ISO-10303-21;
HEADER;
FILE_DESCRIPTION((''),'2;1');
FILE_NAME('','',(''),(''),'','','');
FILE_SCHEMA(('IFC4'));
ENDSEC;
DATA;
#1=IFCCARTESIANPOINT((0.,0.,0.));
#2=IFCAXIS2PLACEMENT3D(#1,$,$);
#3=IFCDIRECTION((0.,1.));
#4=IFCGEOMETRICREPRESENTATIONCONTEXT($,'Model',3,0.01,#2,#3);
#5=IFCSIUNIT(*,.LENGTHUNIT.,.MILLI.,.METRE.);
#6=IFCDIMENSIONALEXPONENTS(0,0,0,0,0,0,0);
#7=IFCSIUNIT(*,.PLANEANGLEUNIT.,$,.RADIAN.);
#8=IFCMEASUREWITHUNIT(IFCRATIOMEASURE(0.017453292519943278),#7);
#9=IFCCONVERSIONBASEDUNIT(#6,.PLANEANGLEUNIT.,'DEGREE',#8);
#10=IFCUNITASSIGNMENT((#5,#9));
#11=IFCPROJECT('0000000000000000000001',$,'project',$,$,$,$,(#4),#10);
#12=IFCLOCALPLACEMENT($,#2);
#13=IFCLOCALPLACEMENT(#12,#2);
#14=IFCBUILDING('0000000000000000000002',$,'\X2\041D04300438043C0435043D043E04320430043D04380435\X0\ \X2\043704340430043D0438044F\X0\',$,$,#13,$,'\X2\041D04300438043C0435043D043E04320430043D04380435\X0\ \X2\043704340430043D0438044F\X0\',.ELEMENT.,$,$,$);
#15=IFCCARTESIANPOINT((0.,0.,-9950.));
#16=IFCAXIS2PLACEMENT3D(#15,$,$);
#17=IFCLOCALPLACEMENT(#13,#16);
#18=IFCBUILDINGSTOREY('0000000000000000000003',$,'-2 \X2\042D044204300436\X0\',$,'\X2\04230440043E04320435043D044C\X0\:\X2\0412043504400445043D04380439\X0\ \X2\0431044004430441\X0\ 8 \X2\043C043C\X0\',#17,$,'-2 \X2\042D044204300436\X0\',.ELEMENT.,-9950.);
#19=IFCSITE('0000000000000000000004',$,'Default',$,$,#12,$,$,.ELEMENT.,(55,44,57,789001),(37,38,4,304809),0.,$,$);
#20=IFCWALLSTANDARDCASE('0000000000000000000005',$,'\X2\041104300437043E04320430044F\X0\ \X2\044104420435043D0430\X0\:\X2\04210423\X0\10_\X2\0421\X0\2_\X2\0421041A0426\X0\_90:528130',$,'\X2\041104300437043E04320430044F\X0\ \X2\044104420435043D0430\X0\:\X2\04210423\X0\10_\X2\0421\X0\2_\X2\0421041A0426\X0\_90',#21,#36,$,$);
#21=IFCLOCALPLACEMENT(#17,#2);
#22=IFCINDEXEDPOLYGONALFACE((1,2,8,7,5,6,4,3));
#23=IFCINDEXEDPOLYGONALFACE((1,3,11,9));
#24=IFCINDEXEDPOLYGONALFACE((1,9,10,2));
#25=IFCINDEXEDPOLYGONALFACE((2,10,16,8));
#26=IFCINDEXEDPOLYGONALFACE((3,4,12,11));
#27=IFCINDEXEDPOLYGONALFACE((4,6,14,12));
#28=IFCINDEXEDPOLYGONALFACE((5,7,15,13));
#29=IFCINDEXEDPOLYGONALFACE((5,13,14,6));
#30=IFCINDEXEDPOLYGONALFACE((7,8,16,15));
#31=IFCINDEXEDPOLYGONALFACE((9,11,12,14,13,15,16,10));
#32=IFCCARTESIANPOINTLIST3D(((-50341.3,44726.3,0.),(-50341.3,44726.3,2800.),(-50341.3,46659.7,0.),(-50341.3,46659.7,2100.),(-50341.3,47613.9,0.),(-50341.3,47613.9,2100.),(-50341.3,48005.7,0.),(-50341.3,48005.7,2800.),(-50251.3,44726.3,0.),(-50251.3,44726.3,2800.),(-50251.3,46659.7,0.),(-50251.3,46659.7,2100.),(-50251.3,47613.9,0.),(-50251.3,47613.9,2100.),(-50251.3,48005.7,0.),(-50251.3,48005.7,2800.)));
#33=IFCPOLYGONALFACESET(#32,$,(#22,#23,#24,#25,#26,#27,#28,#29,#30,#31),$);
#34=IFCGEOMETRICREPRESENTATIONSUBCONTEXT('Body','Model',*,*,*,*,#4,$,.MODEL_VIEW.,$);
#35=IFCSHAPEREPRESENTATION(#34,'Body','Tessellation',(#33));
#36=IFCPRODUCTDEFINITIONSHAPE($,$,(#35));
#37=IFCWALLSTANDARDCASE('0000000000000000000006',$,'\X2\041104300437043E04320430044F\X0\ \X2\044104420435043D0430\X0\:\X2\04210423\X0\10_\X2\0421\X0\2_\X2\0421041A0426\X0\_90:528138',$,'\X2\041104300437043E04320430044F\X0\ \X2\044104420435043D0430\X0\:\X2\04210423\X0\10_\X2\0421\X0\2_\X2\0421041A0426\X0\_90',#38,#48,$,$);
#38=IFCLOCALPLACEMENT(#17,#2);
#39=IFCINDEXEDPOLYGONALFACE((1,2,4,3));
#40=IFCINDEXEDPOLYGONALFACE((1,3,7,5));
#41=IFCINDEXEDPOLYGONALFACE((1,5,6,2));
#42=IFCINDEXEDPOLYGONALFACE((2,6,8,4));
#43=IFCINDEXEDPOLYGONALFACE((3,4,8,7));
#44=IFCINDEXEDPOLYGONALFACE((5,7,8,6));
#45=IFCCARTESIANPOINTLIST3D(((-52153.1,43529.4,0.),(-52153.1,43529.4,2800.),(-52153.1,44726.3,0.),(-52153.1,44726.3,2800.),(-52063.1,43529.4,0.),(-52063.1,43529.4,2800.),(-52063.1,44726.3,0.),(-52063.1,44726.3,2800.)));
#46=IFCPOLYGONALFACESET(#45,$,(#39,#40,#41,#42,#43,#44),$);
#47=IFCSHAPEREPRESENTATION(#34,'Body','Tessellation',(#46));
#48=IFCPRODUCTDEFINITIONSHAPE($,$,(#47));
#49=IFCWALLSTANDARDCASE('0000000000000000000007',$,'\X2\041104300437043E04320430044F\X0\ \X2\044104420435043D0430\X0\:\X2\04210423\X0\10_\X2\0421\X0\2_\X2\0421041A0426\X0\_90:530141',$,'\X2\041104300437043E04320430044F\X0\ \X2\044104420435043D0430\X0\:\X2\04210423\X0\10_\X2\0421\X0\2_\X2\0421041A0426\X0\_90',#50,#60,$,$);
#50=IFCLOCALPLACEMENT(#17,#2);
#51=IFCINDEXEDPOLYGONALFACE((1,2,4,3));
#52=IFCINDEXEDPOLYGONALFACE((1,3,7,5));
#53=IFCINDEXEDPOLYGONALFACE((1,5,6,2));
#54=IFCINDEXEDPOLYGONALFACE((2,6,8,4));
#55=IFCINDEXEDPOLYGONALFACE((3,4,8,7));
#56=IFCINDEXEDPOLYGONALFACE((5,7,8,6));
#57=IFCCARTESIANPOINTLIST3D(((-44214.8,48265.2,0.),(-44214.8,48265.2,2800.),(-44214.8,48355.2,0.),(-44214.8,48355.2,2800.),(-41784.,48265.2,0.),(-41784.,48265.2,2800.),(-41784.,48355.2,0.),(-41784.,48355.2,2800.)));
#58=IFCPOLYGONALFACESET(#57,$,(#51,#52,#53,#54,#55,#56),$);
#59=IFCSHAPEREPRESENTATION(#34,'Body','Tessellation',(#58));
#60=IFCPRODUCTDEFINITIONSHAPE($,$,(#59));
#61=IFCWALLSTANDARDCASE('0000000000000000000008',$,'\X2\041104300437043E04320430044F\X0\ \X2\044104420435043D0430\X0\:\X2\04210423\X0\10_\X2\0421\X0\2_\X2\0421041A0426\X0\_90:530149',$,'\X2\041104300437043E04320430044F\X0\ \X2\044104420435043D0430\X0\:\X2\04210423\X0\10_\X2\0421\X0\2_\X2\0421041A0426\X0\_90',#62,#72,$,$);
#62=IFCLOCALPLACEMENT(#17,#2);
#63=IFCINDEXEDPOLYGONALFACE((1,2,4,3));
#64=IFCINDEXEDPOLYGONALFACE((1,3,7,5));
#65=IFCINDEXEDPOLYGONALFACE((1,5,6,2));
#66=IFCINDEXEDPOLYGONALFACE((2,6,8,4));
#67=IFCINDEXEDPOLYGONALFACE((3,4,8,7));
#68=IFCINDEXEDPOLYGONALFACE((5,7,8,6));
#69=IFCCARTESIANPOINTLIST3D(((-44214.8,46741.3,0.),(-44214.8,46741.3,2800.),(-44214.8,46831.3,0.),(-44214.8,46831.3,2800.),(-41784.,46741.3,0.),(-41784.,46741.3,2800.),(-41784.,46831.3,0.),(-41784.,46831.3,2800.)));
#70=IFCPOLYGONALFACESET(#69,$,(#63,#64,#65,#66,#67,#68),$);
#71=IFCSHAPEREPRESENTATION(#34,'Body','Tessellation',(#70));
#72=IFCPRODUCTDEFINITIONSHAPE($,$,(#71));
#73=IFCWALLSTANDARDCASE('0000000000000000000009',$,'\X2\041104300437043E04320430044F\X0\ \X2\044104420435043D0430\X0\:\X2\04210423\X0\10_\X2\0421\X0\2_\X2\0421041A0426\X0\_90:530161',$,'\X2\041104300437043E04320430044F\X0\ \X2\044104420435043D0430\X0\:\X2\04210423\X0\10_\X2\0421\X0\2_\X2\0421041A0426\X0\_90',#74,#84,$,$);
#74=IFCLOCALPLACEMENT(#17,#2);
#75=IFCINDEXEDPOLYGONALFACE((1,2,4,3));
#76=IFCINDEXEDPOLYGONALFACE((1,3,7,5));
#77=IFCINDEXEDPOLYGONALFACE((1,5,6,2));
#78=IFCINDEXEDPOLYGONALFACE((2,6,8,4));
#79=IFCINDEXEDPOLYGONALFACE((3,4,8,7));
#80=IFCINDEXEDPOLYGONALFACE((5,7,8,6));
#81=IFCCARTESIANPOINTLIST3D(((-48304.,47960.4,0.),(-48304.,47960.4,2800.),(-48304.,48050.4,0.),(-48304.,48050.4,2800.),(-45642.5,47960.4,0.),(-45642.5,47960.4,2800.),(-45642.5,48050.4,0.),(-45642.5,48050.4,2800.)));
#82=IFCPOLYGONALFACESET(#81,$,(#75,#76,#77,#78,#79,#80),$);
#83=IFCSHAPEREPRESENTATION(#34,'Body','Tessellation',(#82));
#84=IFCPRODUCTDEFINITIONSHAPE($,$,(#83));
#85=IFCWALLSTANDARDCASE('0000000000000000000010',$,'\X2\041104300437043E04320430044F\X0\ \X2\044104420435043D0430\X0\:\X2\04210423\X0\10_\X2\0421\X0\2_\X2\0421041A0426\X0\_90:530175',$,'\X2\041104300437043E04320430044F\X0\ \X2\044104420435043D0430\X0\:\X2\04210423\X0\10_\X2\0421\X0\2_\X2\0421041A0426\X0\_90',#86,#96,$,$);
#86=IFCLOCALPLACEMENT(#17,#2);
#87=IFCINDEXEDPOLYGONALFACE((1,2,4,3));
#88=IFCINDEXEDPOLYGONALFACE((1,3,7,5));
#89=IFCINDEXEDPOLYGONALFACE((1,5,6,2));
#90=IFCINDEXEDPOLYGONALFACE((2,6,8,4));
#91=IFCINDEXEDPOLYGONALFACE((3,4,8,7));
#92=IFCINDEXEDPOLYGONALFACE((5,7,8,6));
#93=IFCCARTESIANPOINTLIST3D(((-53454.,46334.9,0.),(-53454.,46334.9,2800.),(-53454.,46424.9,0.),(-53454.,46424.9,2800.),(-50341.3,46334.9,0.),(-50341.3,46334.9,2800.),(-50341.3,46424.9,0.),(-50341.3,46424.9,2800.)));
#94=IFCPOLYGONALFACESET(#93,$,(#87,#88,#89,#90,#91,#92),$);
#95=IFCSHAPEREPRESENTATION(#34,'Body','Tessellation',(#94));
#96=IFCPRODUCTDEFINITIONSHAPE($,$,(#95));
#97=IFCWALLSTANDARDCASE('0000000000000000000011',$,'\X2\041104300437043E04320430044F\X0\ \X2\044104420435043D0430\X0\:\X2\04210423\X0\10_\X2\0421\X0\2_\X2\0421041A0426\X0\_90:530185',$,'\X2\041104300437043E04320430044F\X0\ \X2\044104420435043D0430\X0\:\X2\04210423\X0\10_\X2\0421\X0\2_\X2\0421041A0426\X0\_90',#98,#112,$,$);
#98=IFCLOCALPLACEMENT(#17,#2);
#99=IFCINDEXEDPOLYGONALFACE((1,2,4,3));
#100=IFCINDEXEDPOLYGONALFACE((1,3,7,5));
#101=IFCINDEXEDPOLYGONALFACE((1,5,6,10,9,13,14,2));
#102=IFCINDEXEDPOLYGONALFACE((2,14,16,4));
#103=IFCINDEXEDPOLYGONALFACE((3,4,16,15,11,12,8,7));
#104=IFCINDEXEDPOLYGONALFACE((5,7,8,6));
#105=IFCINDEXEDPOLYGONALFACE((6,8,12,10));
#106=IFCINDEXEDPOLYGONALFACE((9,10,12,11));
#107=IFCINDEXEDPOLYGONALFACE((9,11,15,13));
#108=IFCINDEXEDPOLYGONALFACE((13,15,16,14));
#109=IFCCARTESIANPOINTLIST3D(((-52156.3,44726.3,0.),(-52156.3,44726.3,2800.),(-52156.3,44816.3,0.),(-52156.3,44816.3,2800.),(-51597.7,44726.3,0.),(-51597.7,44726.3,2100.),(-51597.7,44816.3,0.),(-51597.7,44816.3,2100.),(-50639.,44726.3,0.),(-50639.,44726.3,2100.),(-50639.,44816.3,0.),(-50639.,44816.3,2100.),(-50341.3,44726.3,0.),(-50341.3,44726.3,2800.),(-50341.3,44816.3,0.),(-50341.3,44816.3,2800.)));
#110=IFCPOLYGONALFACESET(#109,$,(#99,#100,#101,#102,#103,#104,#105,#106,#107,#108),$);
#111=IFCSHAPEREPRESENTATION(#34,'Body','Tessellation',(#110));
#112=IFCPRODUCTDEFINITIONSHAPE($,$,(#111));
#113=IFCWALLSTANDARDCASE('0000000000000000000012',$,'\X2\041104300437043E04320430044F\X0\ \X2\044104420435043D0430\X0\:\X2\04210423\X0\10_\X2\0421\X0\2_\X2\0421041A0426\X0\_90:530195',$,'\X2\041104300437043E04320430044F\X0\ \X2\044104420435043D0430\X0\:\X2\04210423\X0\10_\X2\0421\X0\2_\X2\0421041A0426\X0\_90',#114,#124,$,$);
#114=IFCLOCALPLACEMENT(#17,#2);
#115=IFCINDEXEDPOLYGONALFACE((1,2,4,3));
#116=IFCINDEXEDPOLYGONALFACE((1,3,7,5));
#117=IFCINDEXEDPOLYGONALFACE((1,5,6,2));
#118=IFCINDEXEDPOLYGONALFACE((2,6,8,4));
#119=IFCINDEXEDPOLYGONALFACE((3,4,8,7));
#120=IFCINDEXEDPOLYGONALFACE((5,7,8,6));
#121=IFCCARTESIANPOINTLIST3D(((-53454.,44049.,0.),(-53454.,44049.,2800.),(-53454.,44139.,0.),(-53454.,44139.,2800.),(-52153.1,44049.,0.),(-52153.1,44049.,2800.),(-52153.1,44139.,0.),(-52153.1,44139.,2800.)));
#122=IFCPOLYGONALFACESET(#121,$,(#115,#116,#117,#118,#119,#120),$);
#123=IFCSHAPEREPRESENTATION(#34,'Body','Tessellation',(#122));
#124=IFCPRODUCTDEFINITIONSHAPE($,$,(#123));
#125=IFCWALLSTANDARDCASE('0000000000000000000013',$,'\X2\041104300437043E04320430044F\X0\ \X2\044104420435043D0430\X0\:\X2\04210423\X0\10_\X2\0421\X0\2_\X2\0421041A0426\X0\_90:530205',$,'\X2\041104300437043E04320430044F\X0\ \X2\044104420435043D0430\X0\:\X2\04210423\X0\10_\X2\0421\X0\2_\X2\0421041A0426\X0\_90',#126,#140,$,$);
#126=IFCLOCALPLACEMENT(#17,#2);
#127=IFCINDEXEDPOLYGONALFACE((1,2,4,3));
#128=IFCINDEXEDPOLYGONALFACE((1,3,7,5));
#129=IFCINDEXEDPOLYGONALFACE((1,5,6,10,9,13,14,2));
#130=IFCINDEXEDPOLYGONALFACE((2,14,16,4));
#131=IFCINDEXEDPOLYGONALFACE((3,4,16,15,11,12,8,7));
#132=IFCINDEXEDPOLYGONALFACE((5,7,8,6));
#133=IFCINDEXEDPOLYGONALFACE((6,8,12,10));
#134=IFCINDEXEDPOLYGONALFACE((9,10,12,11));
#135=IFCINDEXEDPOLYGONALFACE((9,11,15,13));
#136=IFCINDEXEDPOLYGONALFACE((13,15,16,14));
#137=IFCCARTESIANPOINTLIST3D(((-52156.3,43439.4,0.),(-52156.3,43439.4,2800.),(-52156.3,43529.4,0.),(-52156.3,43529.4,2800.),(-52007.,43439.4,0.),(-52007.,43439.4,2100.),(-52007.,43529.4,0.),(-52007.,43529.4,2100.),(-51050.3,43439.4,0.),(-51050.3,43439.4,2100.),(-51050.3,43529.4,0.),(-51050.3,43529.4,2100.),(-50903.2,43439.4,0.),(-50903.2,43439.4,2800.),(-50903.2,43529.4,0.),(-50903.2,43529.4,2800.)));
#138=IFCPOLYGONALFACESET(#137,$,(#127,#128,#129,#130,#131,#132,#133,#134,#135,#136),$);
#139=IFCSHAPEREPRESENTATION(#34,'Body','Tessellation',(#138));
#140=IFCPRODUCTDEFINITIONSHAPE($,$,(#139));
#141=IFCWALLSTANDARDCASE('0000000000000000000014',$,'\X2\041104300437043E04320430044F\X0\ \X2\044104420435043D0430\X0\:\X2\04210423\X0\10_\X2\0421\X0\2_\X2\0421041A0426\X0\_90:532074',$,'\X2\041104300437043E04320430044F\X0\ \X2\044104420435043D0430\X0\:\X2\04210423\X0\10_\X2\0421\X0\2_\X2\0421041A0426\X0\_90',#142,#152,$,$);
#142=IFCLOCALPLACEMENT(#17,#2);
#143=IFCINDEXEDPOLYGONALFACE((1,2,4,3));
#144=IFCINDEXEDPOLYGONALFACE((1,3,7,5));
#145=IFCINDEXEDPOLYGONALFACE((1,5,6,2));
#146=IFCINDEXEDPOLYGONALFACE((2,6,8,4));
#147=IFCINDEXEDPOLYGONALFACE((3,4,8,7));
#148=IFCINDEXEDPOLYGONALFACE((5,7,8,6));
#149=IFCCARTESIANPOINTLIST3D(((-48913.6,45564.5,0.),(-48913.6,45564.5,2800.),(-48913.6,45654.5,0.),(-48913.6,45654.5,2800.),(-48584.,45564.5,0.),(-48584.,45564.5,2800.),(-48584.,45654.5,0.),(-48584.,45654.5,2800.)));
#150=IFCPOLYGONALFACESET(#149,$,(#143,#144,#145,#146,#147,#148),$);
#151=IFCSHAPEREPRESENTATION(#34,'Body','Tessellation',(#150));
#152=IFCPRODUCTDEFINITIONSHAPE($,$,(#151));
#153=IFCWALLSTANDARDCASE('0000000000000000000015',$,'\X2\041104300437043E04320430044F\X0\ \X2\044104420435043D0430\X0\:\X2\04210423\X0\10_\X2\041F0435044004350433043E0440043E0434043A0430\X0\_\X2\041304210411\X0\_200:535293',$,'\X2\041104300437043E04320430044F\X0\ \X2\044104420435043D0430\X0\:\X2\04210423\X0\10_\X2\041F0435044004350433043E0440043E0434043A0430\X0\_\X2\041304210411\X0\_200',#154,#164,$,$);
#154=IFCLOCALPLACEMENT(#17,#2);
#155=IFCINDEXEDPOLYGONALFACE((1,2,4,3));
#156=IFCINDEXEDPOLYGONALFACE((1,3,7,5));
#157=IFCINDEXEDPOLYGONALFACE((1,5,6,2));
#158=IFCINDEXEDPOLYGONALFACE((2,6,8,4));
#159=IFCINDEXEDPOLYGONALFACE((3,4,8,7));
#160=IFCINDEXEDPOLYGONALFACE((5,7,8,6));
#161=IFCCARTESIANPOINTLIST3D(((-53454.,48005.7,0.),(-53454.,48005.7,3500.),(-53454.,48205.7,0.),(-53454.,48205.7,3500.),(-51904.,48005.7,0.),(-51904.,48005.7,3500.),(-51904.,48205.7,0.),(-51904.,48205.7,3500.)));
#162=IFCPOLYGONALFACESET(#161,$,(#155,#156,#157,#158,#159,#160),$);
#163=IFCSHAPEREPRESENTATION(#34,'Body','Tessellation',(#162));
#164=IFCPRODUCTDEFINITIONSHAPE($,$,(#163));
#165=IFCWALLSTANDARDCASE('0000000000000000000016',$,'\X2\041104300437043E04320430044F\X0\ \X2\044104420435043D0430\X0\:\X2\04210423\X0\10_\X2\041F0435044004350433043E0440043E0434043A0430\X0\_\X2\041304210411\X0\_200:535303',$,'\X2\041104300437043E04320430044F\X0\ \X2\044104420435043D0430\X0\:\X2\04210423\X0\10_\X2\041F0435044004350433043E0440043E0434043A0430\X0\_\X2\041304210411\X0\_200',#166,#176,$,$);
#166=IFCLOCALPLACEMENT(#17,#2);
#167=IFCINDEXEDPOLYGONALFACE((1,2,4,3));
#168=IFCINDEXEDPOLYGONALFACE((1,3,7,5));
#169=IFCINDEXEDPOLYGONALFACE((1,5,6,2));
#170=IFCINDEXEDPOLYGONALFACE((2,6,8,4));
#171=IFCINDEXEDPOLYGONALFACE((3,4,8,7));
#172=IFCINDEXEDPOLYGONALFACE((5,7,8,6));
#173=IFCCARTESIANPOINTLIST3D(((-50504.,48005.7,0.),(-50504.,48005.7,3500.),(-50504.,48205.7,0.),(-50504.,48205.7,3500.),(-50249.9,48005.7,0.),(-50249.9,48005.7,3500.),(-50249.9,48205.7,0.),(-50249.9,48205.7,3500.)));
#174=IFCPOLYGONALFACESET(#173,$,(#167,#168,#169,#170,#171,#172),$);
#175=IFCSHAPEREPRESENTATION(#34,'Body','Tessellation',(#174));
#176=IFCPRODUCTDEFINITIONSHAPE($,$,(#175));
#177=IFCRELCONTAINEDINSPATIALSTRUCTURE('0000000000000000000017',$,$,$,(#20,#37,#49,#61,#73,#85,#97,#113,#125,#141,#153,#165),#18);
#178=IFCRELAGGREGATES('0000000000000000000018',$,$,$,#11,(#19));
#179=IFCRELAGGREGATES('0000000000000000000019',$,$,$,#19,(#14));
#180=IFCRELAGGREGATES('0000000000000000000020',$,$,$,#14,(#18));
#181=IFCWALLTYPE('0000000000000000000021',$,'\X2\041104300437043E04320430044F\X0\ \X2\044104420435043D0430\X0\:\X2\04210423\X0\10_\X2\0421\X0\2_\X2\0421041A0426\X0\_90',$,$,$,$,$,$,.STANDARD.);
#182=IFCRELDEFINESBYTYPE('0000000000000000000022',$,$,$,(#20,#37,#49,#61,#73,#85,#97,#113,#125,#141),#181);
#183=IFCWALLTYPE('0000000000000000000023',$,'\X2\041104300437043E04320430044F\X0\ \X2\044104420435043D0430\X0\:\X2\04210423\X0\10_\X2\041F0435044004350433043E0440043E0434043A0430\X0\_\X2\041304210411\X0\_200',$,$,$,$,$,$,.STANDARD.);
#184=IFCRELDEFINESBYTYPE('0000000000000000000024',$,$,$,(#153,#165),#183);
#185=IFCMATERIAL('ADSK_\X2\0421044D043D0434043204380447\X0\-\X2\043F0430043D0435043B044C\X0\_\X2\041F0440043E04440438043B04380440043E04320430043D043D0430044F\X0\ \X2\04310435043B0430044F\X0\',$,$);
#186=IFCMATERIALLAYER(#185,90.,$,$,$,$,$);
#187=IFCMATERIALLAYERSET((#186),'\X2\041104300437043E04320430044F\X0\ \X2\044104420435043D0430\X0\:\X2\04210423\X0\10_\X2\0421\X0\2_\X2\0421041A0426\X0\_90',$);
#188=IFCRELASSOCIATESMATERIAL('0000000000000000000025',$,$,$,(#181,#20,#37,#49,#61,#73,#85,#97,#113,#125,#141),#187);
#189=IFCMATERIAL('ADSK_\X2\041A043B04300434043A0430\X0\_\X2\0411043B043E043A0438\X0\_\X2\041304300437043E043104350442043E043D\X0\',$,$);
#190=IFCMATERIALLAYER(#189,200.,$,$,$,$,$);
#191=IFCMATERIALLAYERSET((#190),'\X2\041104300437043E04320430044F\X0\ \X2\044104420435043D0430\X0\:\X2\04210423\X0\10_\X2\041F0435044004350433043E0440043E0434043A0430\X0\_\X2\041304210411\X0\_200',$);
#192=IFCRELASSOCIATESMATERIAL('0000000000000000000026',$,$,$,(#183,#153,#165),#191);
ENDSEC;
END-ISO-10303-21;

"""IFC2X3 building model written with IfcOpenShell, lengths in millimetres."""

from ifc_helpers import new_model, entity, si_unit, converted_unit, direction, frame, frame_2d, origin, place, context, subcontext, project, spatial, rectangle, extrude, material, layer, layer_set, layer_usage, type_object, element, save


model = new_model("IFC2X3")

# Units and contexts
model_context = context("Model", 3, precision=0.01, world=origin(), true_north=direction((0.0, 1.0)))
body_context = subcontext(model_context, "Body", "Model", "MODEL_VIEW")
ifc_project = project(units=[si_unit("LENGTHUNIT", "METRE", prefix="MILLI"), converted_unit("PLANEANGLEUNIT", "DEGREE", entity("IfcRatioMeasure", 0.017453292519943278), si_unit("PLANEANGLEUNIT", "RADIAN"), dimensions=[0, 0, 0, 0, 0, 0, 0])], contexts=[model_context])

# Site, building, storey
site_placement = place(None, origin())
site = spatial("IfcSite", under=ifc_project, at=site_placement, Name="Default", CompositionType="ELEMENT", RefLatitude=(55, 44, 57, 789001), RefLongitude=(37, 38, 4, 304809), RefElevation=0.0)
building_placement = place(site_placement, origin())
building = spatial("IfcBuilding", under=site, at=building_placement, Name="Наименование здания", LongName="Наименование здания", CompositionType="ELEMENT")
storey_placement = place(building_placement, frame((0.0, 0.0, -9950.0)))
storey = spatial("IfcBuildingStorey", under=building, at=storey_placement, Name="-2 Этаж", ObjectType="Уровень:Верхний брус 8 мм", LongName="-2 Этаж", CompositionType="ELEMENT", Elevation=-9950.0)

# Shared definitions
ifc_material_1 = material(Name="ADSK_Сэндвич-панель_Профилированная белая")
ifc_layer_1 = layer(ifc_material_1, 90.0)
ifc_layer_set_1 = layer_set([ifc_layer_1], Name="Базовая стена:СУ10_С2_СКЦ_90")
ifc_layer_usage_1 = layer_usage(ifc_layer_set_1, "AXIS2", "NEGATIVE", 45.0)
wall_type_1 = type_object("IfcWallType", Name="Базовая стена:СУ10_С2_СКЦ_90", PredefinedType="STANDARD", material=ifc_layer_set_1)

# Wall, opening
wall_1_placement = place(storey_placement, frame((-50296.3, 48005.7, 0.0), z_axis=(0.0, 0.0, 1.0), x_axis=(0.0, -1.0, 0.0)))
wall_1 = element("IfcWallStandardCase", 1, at=wall_1_placement, inside=storey, type_object=wall_type_1, material=ifc_layer_usage_1, Name="Базовая стена:СУ10_С2_СКЦ_90:528130", ObjectType="Базовая стена:СУ10_С2_СКЦ_90", context=body_context, shape_type="SweptSolid", body=[
    extrude(rectangle(XDim=3279.4, YDim=90.0, at=frame_2d((1639.7, 0.0), x_axis=(1.0, 0.0))), origin(), (0.0, 0.0, 1.0), 2800.0),
])
opening_1_placement = place(wall_1_placement, origin())
element("IfcOpeningElement", 2, at=opening_1_placement, cuts=wall_1, ObjectType="Opening", context=body_context, shape_type="SweptSolid", body=[
    extrude(rectangle(XDim=2100.0, YDim=954.2, at=frame_2d((0.0, 0.0), x_axis=(1.0, 0.0))), frame((868.8, -45.0, 1050.0), z_axis=(0.0, 1.0, 0.0), x_axis=(0.0, 0.0, -1.0)), (0.0, 0.0, 1.0), 90.0),
])

# Walls
wall_2_placement = place(storey_placement, frame((-52108.1, 44726.3, 0.0), z_axis=(0.0, 0.0, 1.0), x_axis=(0.0, -1.0, 0.0)))
element("IfcWallStandardCase", 3, at=wall_2_placement, inside=storey, type_object=wall_type_1, material=ifc_layer_usage_1, Name="Базовая стена:СУ10_С2_СКЦ_90:528138", ObjectType="Базовая стена:СУ10_С2_СКЦ_90", context=body_context, shape_type="SweptSolid", body=[
    extrude(rectangle(XDim=1196.9, YDim=90.0, at=frame_2d((598.4, 0.0), x_axis=(-1.0, 0.0))), origin(), (0.0, 0.0, 1.0), 2800.0),
])
wall_3_placement = place(storey_placement, frame((-41784.0, 48310.2, 0.0), z_axis=(0.0, 0.0, 1.0), x_axis=(-1.0, 0.0, 0.0)))
element("IfcWallStandardCase", 4, at=wall_3_placement, inside=storey, type_object=wall_type_1, material=ifc_layer_usage_1, Name="Базовая стена:СУ10_С2_СКЦ_90:530141", ObjectType="Базовая стена:СУ10_С2_СКЦ_90", context=body_context, shape_type="SweptSolid", body=[
    extrude(rectangle(XDim=2430.8, YDim=90.0, at=frame_2d((1215.4, 0.0), x_axis=(-1.0, 0.0))), origin(), (0.0, 0.0, 1.0), 2800.0),
])
wall_4_placement = place(storey_placement, frame((-41784.0, 46786.3, 0.0), z_axis=(0.0, 0.0, 1.0), x_axis=(-1.0, 0.0, 0.0)))
element("IfcWallStandardCase", 5, at=wall_4_placement, inside=storey, type_object=wall_type_1, material=ifc_layer_usage_1, Name="Базовая стена:СУ10_С2_СКЦ_90:530149", ObjectType="Базовая стена:СУ10_С2_СКЦ_90", context=body_context, shape_type="SweptSolid", body=[
    extrude(rectangle(XDim=2430.8, YDim=90.0, at=frame_2d((1215.4, 0.0), x_axis=(-1.0, 0.0))), origin(), (0.0, 0.0, 1.0), 2800.0),
])
wall_5_placement = place(storey_placement, frame((-45642.5, 48005.4, 0.0), z_axis=(0.0, 0.0, 1.0), x_axis=(-1.0, 0.0, 0.0)))
element("IfcWallStandardCase", 6, at=wall_5_placement, inside=storey, type_object=wall_type_1, material=ifc_layer_usage_1, Name="Базовая стена:СУ10_С2_СКЦ_90:530161", ObjectType="Базовая стена:СУ10_С2_СКЦ_90", context=body_context, shape_type="SweptSolid", body=[
    extrude(rectangle(XDim=2661.6, YDim=90.0, at=frame_2d((1330.8, 0.0), x_axis=(-1.0, 0.0))), origin(), (0.0, 0.0, 1.0), 2800.0),
])
wall_6_placement = place(storey_placement, frame((-50341.3, 46379.9, 0.0), z_axis=(0.0, 0.0, 1.0), x_axis=(-1.0, 0.0, 0.0)))
element("IfcWallStandardCase", 7, at=wall_6_placement, inside=storey, type_object=wall_type_1, material=ifc_layer_usage_1, Name="Базовая стена:СУ10_С2_СКЦ_90:530175", ObjectType="Базовая стена:СУ10_С2_СКЦ_90", context=body_context, shape_type="SweptSolid", body=[
    extrude(rectangle(XDim=3112.7, YDim=90.0, at=frame_2d((1556.3, 0.0), x_axis=(-1.0, 0.0))), origin(), (0.0, 0.0, 1.0), 2800.0),
])

# Wall, opening
wall_7_placement = place(storey_placement, frame((-50341.3, 44771.3, 0.0), z_axis=(0.0, 0.0, 1.0), x_axis=(-1.0, 0.0, 0.0)))
wall_7 = element("IfcWallStandardCase", 8, at=wall_7_placement, inside=storey, type_object=wall_type_1, material=ifc_layer_usage_1, Name="Базовая стена:СУ10_С2_СКЦ_90:530185", ObjectType="Базовая стена:СУ10_С2_СКЦ_90", context=body_context, shape_type="SweptSolid", body=[
    extrude(rectangle(XDim=1814.9, YDim=90.0, at=frame_2d((907.5, 0.0), x_axis=(1.0, 0.0))), origin(), (0.0, 0.0, 1.0), 2800.0),
])
opening_2_placement = place(wall_7_placement, origin())
element("IfcOpeningElement", 9, at=opening_2_placement, cuts=wall_7, ObjectType="Opening", context=body_context, shape_type="SweptSolid", body=[
    extrude(rectangle(XDim=2100.0, YDim=958.7, at=frame_2d((0.0, 0.0), x_axis=(1.0, 0.0))), frame((777.1, -45.0, 1050.0), z_axis=(0.0, 1.0, 0.0), x_axis=(0.0, 0.0, -1.0)), (0.0, 0.0, 1.0), 90.0),
])

# Wall
wall_8_placement = place(storey_placement, frame((-52153.1, 44094.0, 0.0), z_axis=(0.0, 0.0, 1.0), x_axis=(-1.0, 0.0, 0.0)))
element("IfcWallStandardCase", 10, at=wall_8_placement, inside=storey, type_object=wall_type_1, material=ifc_layer_usage_1, Name="Базовая стена:СУ10_С2_СКЦ_90:530195", ObjectType="Базовая стена:СУ10_С2_СКЦ_90", context=body_context, shape_type="SweptSolid", body=[
    extrude(rectangle(XDim=1300.9, YDim=90.0, at=frame_2d((650.4, 0.0), x_axis=(-1.0, 0.0))), origin(), (0.0, 0.0, 1.0), 2800.0),
])

# Wall, opening
wall_9_placement = place(storey_placement, frame((-50903.2, 43484.4, 0.0), z_axis=(0.0, 0.0, 1.0), x_axis=(-1.0, 0.0, 0.0)))
wall_9 = element("IfcWallStandardCase", 11, at=wall_9_placement, inside=storey, type_object=wall_type_1, material=ifc_layer_usage_1, Name="Базовая стена:СУ10_С2_СКЦ_90:530205", ObjectType="Базовая стена:СУ10_С2_СКЦ_90", context=body_context, shape_type="SweptSolid", body=[
    extrude(rectangle(XDim=1253.0, YDim=90.0, at=frame_2d((626.5, 0.0), x_axis=(1.0, 0.0))), origin(), (0.0, 0.0, 1.0), 2800.0),
])
opening_3_placement = place(wall_9_placement, origin())
element("IfcOpeningElement", 12, at=opening_3_placement, cuts=wall_9, ObjectType="Opening", context=body_context, shape_type="SweptSolid", body=[
    extrude(rectangle(XDim=2100.0, YDim=956.7, at=frame_2d((0.0, 0.0), x_axis=(1.0, 0.0))), frame((625.4, -45.0, 1050.0), z_axis=(0.0, 1.0, 0.0), x_axis=(0.0, 0.0, -1.0)), (0.0, 0.0, 1.0), 90.0),
])

# Walls
wall_10_placement = place(storey_placement, frame((-48584.0, 45609.5, 0.0), z_axis=(0.0, 0.0, 1.0), x_axis=(-1.0, 0.0, 0.0)))
element("IfcWallStandardCase", 13, at=wall_10_placement, inside=storey, type_object=wall_type_1, material=ifc_layer_usage_1, Name="Базовая стена:СУ10_С2_СКЦ_90:532074", ObjectType="Базовая стена:СУ10_С2_СКЦ_90", context=body_context, shape_type="SweptSolid", body=[
    extrude(rectangle(XDim=329.6, YDim=90.0, at=frame_2d((164.8, 0.0), x_axis=(-1.0, 0.0))), origin(), (0.0, 0.0, 1.0), 2800.0),
])
ifc_material_2 = material(Name="ADSK_Кладка_Блоки_Газобетон")
ifc_layer_2 = layer(ifc_material_2, 200.0)
ifc_layer_set_2 = layer_set([ifc_layer_2], Name="Базовая стена:СУ10_Перегородка_ГСБ_200")
ifc_layer_usage_2 = layer_usage(ifc_layer_set_2, "AXIS2", "NEGATIVE", 100.0)
wall_type_2 = type_object("IfcWallType", Name="Базовая стена:СУ10_Перегородка_ГСБ_200", PredefinedType="STANDARD", material=ifc_layer_set_2)
wall_11_placement = place(storey_placement, frame((-51904.0, 48105.7, 0.0), z_axis=(0.0, 0.0, 1.0), x_axis=(-1.0, 0.0, 0.0)))
element("IfcWallStandardCase", 14, at=wall_11_placement, inside=storey, type_object=wall_type_2, material=ifc_layer_usage_2, Name="Базовая стена:СУ10_Перегородка_ГСБ_200:535293", ObjectType="Базовая стена:СУ10_Перегородка_ГСБ_200", context=body_context, shape_type="SweptSolid", body=[
    extrude(rectangle(XDim=1550.0, YDim=200.0, at=frame_2d((775.0, 0.0), x_axis=(-1.0, 0.0))), origin(), (0.0, 0.0, 1.0), 3500.0),
])
wall_12_placement = place(storey_placement, frame((-50249.9, 48105.7, 0.0), z_axis=(0.0, 0.0, 1.0), x_axis=(-1.0, 0.0, 0.0)))
element("IfcWallStandardCase", 15, at=wall_12_placement, inside=storey, type_object=wall_type_2, material=ifc_layer_usage_2, Name="Базовая стена:СУ10_Перегородка_ГСБ_200:535303", ObjectType="Базовая стена:СУ10_Перегородка_ГСБ_200", context=body_context, shape_type="SweptSolid", body=[
    extrude(rectangle(XDim=254.1, YDim=200.0, at=frame_2d((127.0, 0.0), x_axis=(-1.0, 0.0))), origin(), (0.0, 0.0, 1.0), 3500.0),
])

save(model, "model.ifc")
